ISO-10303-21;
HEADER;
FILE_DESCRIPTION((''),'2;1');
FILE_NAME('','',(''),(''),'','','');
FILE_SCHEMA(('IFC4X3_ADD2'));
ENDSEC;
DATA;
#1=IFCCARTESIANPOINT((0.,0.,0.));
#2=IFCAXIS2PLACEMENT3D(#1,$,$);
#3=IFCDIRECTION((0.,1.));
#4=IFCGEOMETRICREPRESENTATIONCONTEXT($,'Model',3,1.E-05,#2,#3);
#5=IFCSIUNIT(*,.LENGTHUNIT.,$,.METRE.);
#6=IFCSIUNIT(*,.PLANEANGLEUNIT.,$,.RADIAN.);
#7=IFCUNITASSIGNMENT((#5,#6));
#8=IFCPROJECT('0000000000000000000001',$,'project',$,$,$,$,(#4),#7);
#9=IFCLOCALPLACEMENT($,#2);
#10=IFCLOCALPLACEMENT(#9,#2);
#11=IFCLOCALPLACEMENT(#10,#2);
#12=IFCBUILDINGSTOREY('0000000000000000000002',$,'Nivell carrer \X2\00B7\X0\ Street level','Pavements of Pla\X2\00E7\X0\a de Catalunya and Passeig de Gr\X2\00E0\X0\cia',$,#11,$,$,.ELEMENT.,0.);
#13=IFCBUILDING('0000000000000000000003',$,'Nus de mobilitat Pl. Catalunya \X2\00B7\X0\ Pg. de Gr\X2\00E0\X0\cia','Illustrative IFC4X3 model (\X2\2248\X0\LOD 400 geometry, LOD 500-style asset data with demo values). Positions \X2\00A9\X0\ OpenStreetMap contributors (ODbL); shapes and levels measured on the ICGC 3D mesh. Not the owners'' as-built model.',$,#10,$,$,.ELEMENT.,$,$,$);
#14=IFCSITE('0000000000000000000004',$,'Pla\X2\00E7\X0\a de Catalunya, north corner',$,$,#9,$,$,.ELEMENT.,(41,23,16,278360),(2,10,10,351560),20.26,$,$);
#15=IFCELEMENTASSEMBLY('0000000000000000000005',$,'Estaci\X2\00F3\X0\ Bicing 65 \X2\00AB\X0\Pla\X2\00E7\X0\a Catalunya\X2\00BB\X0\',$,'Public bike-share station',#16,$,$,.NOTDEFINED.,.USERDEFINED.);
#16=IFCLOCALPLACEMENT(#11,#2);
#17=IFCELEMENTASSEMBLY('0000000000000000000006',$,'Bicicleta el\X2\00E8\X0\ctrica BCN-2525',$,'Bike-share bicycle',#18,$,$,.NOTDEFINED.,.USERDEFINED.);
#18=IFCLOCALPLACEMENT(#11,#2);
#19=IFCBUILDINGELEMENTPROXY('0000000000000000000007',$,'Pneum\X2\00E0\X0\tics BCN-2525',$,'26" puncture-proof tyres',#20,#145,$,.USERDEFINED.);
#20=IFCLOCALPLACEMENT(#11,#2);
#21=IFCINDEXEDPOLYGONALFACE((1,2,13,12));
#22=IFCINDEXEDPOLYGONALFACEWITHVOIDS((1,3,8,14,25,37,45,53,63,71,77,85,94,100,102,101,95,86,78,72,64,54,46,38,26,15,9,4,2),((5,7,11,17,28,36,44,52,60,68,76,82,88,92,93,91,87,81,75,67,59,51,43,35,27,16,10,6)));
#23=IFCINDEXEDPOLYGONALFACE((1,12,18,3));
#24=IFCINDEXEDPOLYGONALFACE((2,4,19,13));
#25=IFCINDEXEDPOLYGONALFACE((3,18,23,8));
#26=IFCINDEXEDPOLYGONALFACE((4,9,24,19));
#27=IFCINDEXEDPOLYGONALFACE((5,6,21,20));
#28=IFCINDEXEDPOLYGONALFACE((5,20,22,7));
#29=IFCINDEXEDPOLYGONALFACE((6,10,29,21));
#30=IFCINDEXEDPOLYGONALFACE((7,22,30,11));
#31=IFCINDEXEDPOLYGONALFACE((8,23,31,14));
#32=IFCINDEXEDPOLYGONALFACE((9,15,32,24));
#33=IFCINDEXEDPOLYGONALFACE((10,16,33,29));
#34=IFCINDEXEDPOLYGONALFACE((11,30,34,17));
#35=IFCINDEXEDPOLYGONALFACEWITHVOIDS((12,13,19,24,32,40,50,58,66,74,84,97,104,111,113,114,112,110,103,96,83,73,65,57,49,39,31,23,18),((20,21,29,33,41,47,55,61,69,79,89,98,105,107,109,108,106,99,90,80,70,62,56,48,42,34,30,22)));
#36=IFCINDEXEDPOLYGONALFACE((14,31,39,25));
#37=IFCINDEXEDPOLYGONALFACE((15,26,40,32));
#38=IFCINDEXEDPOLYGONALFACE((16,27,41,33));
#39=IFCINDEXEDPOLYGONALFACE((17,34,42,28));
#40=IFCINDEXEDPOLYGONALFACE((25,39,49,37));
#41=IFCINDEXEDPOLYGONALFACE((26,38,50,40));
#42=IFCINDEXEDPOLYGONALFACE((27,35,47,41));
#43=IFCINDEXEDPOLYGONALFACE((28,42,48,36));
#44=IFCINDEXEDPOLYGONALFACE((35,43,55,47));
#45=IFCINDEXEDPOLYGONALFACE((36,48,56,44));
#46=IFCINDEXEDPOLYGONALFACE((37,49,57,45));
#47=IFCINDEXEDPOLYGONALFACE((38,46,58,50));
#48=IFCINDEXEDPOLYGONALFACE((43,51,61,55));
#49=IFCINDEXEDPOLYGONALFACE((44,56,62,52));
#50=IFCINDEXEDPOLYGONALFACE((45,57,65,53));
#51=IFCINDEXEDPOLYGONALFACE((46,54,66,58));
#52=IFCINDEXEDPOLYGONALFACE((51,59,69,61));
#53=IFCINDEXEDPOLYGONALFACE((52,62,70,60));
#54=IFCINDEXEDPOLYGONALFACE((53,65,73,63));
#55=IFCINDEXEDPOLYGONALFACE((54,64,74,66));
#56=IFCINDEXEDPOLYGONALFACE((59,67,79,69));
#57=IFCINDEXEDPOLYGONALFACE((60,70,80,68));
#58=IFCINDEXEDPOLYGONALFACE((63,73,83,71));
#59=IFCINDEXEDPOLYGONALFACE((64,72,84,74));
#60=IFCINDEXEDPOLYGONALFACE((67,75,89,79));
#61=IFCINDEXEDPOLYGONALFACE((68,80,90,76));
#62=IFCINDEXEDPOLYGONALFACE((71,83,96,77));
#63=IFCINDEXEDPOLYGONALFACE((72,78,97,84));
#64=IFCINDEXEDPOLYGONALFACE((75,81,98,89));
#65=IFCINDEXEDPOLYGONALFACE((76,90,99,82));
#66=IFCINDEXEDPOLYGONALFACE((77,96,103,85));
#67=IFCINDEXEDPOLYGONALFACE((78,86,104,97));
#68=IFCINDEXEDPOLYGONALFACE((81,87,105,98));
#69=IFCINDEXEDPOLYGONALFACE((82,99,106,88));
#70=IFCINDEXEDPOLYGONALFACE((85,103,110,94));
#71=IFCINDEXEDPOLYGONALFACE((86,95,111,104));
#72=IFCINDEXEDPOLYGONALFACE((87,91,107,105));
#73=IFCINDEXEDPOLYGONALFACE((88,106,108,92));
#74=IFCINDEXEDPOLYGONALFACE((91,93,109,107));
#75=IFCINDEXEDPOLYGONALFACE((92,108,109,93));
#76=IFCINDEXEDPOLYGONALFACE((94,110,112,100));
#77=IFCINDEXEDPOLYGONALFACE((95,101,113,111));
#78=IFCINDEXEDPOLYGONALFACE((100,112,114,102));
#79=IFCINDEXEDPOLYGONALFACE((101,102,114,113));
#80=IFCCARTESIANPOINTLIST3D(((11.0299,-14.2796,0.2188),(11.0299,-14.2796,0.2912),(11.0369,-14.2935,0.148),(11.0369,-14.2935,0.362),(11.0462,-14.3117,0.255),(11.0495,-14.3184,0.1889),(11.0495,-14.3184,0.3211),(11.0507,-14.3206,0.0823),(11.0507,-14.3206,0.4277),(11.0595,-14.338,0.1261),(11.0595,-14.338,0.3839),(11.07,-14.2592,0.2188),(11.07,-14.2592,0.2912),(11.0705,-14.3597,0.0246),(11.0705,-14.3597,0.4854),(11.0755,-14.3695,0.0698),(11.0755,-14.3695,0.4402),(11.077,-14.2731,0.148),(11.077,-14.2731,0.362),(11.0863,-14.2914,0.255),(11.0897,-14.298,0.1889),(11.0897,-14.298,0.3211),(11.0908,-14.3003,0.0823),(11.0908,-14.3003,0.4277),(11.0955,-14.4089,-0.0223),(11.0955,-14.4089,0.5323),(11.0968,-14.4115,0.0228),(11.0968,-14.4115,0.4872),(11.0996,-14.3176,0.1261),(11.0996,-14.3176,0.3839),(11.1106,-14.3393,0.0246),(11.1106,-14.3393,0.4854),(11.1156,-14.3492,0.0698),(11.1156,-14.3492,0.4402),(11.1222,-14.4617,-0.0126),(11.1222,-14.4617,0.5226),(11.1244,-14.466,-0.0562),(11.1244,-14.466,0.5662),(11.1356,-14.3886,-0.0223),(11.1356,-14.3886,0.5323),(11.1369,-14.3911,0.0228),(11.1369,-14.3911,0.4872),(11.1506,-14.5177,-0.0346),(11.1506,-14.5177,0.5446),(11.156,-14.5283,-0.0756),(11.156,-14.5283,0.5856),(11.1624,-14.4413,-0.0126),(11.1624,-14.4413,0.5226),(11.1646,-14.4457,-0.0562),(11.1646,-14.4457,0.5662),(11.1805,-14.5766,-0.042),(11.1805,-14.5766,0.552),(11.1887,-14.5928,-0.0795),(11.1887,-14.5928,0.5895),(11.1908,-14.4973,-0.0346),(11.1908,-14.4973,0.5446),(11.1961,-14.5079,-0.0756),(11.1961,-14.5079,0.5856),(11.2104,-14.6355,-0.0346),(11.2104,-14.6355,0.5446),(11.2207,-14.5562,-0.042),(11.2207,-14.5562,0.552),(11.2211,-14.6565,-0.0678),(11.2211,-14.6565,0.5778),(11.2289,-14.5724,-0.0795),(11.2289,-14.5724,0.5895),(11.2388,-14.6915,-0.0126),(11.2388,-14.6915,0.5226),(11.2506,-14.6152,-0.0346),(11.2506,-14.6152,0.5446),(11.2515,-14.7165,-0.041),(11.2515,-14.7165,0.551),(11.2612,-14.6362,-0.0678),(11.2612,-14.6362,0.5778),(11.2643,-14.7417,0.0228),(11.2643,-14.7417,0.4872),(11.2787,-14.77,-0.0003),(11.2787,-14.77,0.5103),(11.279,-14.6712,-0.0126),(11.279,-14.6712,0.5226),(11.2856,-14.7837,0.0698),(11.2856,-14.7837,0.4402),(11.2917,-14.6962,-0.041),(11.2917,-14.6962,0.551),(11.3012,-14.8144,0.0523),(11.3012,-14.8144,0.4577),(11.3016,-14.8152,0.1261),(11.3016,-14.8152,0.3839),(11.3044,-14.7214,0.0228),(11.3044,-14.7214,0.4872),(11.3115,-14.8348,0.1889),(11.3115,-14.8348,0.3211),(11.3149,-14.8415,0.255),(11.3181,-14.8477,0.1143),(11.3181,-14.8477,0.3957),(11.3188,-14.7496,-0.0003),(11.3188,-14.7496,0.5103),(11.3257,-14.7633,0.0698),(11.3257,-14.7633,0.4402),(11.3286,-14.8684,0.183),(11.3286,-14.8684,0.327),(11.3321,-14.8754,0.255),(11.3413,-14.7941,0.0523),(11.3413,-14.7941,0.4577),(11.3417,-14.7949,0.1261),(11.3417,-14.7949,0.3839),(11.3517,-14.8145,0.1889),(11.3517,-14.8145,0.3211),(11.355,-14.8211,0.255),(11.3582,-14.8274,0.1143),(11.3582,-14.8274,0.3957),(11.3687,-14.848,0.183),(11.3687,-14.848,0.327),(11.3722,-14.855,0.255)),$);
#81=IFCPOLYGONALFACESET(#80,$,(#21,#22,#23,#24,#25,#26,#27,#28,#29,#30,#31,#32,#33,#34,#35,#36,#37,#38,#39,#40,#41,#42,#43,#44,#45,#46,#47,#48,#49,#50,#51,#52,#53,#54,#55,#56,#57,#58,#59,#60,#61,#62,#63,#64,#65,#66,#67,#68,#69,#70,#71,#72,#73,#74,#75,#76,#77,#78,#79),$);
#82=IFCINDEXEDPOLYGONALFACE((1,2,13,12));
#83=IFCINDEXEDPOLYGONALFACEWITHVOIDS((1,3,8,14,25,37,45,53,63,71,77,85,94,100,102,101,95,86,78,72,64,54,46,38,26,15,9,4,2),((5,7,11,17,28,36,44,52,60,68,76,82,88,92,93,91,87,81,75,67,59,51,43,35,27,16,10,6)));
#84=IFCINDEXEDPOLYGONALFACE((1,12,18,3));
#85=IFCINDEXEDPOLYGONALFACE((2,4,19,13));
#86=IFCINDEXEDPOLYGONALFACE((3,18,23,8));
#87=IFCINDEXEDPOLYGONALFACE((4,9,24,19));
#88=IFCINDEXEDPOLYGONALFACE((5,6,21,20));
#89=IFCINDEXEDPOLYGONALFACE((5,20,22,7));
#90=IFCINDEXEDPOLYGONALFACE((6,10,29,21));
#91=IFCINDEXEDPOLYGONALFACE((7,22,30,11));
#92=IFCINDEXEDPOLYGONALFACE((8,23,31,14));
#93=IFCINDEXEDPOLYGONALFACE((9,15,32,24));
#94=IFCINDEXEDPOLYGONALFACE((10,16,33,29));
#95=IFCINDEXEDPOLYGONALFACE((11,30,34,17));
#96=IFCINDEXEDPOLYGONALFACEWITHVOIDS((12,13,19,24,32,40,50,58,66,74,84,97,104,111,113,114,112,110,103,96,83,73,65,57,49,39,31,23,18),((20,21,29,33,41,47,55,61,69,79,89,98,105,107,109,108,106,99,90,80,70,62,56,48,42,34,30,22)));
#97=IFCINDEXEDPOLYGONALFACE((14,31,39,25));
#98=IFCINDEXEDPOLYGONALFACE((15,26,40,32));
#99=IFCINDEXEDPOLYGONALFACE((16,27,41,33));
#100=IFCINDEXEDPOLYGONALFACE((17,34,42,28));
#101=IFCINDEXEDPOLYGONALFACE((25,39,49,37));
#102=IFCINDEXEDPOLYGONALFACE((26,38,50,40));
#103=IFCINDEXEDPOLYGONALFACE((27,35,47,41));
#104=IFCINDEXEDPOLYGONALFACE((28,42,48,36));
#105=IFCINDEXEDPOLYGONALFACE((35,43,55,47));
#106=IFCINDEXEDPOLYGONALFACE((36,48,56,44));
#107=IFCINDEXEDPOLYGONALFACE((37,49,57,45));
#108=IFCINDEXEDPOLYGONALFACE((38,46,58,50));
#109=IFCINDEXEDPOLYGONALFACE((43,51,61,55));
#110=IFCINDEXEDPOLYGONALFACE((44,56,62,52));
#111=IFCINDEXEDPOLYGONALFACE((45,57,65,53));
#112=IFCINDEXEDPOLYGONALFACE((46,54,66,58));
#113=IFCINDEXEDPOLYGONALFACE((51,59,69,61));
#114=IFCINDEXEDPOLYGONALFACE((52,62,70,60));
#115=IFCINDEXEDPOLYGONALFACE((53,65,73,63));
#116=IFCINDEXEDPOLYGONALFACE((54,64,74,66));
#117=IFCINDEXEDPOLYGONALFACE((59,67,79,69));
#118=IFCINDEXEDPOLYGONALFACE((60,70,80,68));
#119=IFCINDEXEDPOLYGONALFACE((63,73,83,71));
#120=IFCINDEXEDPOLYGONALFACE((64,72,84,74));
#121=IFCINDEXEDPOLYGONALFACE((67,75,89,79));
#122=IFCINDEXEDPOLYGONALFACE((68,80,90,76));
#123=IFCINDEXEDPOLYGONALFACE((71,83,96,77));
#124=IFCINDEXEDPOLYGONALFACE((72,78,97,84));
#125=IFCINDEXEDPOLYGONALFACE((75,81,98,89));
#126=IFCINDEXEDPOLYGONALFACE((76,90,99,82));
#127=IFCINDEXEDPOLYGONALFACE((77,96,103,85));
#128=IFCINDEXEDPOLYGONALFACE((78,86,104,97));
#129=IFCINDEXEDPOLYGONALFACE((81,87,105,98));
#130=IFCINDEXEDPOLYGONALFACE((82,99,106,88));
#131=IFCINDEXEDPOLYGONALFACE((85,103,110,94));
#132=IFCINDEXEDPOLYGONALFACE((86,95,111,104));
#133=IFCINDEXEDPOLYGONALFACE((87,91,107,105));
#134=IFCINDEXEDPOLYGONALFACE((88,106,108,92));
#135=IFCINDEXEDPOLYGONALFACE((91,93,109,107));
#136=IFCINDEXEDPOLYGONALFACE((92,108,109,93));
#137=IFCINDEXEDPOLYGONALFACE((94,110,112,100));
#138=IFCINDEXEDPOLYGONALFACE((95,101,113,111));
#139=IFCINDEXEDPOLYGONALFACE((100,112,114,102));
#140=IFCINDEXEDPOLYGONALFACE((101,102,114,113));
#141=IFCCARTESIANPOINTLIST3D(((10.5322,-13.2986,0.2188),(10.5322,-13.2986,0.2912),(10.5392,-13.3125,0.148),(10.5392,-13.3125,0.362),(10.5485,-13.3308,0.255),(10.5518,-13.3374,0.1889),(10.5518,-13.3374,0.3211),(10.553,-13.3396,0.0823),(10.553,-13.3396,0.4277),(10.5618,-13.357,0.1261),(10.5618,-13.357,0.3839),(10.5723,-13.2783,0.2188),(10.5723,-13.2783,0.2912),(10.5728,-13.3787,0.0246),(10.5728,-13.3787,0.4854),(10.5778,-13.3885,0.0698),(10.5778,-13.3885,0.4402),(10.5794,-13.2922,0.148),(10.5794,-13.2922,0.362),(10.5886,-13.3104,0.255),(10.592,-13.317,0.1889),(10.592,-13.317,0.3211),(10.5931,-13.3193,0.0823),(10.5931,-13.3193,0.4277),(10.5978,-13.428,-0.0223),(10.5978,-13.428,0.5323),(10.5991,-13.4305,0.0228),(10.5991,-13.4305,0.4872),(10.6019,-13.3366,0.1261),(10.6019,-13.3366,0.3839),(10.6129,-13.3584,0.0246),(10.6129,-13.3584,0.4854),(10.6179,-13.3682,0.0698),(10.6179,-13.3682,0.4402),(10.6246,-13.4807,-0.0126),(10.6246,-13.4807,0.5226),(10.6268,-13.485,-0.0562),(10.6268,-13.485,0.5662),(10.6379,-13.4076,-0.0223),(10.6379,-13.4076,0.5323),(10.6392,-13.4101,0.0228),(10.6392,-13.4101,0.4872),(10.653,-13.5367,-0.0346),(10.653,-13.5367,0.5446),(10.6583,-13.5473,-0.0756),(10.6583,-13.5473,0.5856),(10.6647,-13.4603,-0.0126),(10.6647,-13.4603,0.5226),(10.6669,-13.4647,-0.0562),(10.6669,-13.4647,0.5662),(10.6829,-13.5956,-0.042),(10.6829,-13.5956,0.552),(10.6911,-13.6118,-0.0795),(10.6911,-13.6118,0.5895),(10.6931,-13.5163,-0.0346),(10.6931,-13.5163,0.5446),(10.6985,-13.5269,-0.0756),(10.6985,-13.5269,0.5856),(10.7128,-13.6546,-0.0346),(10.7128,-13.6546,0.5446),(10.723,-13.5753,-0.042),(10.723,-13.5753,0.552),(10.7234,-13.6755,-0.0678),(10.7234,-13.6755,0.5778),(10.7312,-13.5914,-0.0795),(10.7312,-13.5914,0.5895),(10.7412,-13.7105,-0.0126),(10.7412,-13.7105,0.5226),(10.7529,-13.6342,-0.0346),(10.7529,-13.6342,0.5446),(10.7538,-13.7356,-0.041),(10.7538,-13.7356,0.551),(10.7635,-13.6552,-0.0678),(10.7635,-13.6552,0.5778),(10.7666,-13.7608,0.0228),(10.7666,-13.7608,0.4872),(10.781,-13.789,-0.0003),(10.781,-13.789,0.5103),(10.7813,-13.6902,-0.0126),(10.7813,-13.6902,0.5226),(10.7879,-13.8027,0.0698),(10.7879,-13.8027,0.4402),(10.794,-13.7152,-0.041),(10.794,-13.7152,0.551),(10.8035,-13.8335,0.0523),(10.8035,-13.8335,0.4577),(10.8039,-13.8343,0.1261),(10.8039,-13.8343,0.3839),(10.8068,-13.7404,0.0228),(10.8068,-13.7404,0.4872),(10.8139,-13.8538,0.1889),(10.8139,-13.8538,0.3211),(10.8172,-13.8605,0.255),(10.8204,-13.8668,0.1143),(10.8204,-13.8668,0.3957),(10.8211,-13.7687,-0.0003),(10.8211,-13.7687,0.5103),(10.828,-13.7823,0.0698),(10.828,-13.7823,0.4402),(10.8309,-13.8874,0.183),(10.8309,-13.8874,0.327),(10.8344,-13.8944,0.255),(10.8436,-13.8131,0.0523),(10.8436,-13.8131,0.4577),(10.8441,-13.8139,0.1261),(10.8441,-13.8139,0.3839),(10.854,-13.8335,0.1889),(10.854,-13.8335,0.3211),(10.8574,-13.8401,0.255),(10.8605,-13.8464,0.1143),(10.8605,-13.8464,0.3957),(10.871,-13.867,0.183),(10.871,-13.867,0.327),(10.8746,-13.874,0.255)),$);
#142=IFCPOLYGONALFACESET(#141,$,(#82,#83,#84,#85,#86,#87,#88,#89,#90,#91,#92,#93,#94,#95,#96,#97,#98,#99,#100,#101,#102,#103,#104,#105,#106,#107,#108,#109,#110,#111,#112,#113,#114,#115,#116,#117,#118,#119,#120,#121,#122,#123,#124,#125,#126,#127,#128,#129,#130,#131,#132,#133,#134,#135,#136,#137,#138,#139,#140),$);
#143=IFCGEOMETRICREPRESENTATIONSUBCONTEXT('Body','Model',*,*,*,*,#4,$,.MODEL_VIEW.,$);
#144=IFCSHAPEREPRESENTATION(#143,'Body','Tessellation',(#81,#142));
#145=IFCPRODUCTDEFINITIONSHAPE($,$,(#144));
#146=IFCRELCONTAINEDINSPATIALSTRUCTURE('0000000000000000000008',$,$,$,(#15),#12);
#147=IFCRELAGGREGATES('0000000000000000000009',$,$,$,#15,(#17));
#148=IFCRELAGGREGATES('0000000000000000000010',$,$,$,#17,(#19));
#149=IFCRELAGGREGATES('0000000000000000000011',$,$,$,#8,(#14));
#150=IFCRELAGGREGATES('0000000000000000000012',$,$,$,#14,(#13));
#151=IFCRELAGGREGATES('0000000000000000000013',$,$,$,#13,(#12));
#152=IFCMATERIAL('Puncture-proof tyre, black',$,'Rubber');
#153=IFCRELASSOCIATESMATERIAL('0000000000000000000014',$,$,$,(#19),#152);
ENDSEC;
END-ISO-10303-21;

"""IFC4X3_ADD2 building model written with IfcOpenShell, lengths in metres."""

from ifc_helpers import new_model, si_unit, direction, frame, origin, origin_2d_with_axis, place, context, subcontext, project, spatial, hollow_circle, extrude, material, element, aggregate, save


model = new_model("IFC4X3_ADD2")

# Units and contexts
model_context = context("Model", 3, precision=1e-05, world=origin(), true_north=direction((0.0, 1.0)))
body_context = subcontext(model_context, "Body", "Model", "MODEL_VIEW")
ifc_project = project(units=[si_unit("LENGTHUNIT", "METRE"), si_unit("PLANEANGLEUNIT", "RADIAN")], contexts=[model_context])

# Site, building, storey
site_placement = place(None, origin())
site = spatial("IfcSite", under=ifc_project, at=site_placement, Name="Plaça de Catalunya, north corner", CompositionType="ELEMENT", RefLatitude=(41, 23, 16, 278360), RefLongitude=(2, 10, 10, 351560), RefElevation=20.26)
building_placement = place(site_placement, origin())
building = spatial("IfcBuilding", under=site, at=building_placement, Name="Nus de mobilitat Pl. Catalunya · Pg. de Gràcia", Description="Illustrative IFC4X3 model (≈LOD 400 geometry, LOD 500-style asset data with demo values). Positions © OpenStreetMap contributors (ODbL); shapes and levels measured on the ICGC 3D mesh. Not the owners' as-built model.", CompositionType="ELEMENT")
storey_placement = place(building_placement, origin())
storey = spatial("IfcBuildingStorey", under=building, at=storey_placement, Name="Nivell carrer · Street level", Description="Pavements of Plaça de Catalunya and Passeig de Gràcia", CompositionType="ELEMENT", Elevation=0.0)

# Element assemblies, building element proxy
assembly_1_placement = place(building_placement, origin())
assembly_1 = element("IfcElementAssembly", 1, at=assembly_1_placement, inside=storey, Name="Estació Bicing 65 «Plaça Catalunya»", ObjectType="Public bike-share station", AssemblyPlace="NOTDEFINED", PredefinedType="USERDEFINED")
ifc_material_1 = material(Name="Puncture-proof tyre, black", Category="Rubber")
assembly_2_placement = place(building_placement, origin())
assembly_2 = element("IfcElementAssembly", 2, at=assembly_2_placement, Name="Bicicleta elèctrica BCN-2525", ObjectType="Bike-share bicycle", AssemblyPlace="NOTDEFINED", PredefinedType="USERDEFINED")
aggregate(assembly_1, [assembly_2])
proxy_1_placement = place(building_placement, origin())
proxy_1 = element("IfcBuildingElementProxy", 3, at=proxy_1_placement, material=ifc_material_1, Name="Pneumàtics BCN-2525", ObjectType="26\" puncture-proof tyres", PredefinedType="USERDEFINED", context=body_context, shape_type="SweptSolid", body=[
    extrude(hollow_circle(Radius=0.335, WallThickness=0.038, at=origin_2d_with_axis()), frame((11.1805, -14.5766, 0.255), z_axis=(0.891798, 0.452435, 0.0), x_axis=(0.452435, -0.891798, 0.0)), (0.0, 0.0, 1.0), 0.045),
    extrude(hollow_circle(Radius=0.335, WallThickness=0.038, at=origin_2d_with_axis()), frame((10.6829, -13.5956, 0.255), z_axis=(0.891798, 0.452435, 0.0), x_axis=(0.452435, -0.891798, 0.0)), (0.0, 0.0, 1.0), 0.045),
])
aggregate(assembly_2, [proxy_1])

save(model, "model.ifc")
